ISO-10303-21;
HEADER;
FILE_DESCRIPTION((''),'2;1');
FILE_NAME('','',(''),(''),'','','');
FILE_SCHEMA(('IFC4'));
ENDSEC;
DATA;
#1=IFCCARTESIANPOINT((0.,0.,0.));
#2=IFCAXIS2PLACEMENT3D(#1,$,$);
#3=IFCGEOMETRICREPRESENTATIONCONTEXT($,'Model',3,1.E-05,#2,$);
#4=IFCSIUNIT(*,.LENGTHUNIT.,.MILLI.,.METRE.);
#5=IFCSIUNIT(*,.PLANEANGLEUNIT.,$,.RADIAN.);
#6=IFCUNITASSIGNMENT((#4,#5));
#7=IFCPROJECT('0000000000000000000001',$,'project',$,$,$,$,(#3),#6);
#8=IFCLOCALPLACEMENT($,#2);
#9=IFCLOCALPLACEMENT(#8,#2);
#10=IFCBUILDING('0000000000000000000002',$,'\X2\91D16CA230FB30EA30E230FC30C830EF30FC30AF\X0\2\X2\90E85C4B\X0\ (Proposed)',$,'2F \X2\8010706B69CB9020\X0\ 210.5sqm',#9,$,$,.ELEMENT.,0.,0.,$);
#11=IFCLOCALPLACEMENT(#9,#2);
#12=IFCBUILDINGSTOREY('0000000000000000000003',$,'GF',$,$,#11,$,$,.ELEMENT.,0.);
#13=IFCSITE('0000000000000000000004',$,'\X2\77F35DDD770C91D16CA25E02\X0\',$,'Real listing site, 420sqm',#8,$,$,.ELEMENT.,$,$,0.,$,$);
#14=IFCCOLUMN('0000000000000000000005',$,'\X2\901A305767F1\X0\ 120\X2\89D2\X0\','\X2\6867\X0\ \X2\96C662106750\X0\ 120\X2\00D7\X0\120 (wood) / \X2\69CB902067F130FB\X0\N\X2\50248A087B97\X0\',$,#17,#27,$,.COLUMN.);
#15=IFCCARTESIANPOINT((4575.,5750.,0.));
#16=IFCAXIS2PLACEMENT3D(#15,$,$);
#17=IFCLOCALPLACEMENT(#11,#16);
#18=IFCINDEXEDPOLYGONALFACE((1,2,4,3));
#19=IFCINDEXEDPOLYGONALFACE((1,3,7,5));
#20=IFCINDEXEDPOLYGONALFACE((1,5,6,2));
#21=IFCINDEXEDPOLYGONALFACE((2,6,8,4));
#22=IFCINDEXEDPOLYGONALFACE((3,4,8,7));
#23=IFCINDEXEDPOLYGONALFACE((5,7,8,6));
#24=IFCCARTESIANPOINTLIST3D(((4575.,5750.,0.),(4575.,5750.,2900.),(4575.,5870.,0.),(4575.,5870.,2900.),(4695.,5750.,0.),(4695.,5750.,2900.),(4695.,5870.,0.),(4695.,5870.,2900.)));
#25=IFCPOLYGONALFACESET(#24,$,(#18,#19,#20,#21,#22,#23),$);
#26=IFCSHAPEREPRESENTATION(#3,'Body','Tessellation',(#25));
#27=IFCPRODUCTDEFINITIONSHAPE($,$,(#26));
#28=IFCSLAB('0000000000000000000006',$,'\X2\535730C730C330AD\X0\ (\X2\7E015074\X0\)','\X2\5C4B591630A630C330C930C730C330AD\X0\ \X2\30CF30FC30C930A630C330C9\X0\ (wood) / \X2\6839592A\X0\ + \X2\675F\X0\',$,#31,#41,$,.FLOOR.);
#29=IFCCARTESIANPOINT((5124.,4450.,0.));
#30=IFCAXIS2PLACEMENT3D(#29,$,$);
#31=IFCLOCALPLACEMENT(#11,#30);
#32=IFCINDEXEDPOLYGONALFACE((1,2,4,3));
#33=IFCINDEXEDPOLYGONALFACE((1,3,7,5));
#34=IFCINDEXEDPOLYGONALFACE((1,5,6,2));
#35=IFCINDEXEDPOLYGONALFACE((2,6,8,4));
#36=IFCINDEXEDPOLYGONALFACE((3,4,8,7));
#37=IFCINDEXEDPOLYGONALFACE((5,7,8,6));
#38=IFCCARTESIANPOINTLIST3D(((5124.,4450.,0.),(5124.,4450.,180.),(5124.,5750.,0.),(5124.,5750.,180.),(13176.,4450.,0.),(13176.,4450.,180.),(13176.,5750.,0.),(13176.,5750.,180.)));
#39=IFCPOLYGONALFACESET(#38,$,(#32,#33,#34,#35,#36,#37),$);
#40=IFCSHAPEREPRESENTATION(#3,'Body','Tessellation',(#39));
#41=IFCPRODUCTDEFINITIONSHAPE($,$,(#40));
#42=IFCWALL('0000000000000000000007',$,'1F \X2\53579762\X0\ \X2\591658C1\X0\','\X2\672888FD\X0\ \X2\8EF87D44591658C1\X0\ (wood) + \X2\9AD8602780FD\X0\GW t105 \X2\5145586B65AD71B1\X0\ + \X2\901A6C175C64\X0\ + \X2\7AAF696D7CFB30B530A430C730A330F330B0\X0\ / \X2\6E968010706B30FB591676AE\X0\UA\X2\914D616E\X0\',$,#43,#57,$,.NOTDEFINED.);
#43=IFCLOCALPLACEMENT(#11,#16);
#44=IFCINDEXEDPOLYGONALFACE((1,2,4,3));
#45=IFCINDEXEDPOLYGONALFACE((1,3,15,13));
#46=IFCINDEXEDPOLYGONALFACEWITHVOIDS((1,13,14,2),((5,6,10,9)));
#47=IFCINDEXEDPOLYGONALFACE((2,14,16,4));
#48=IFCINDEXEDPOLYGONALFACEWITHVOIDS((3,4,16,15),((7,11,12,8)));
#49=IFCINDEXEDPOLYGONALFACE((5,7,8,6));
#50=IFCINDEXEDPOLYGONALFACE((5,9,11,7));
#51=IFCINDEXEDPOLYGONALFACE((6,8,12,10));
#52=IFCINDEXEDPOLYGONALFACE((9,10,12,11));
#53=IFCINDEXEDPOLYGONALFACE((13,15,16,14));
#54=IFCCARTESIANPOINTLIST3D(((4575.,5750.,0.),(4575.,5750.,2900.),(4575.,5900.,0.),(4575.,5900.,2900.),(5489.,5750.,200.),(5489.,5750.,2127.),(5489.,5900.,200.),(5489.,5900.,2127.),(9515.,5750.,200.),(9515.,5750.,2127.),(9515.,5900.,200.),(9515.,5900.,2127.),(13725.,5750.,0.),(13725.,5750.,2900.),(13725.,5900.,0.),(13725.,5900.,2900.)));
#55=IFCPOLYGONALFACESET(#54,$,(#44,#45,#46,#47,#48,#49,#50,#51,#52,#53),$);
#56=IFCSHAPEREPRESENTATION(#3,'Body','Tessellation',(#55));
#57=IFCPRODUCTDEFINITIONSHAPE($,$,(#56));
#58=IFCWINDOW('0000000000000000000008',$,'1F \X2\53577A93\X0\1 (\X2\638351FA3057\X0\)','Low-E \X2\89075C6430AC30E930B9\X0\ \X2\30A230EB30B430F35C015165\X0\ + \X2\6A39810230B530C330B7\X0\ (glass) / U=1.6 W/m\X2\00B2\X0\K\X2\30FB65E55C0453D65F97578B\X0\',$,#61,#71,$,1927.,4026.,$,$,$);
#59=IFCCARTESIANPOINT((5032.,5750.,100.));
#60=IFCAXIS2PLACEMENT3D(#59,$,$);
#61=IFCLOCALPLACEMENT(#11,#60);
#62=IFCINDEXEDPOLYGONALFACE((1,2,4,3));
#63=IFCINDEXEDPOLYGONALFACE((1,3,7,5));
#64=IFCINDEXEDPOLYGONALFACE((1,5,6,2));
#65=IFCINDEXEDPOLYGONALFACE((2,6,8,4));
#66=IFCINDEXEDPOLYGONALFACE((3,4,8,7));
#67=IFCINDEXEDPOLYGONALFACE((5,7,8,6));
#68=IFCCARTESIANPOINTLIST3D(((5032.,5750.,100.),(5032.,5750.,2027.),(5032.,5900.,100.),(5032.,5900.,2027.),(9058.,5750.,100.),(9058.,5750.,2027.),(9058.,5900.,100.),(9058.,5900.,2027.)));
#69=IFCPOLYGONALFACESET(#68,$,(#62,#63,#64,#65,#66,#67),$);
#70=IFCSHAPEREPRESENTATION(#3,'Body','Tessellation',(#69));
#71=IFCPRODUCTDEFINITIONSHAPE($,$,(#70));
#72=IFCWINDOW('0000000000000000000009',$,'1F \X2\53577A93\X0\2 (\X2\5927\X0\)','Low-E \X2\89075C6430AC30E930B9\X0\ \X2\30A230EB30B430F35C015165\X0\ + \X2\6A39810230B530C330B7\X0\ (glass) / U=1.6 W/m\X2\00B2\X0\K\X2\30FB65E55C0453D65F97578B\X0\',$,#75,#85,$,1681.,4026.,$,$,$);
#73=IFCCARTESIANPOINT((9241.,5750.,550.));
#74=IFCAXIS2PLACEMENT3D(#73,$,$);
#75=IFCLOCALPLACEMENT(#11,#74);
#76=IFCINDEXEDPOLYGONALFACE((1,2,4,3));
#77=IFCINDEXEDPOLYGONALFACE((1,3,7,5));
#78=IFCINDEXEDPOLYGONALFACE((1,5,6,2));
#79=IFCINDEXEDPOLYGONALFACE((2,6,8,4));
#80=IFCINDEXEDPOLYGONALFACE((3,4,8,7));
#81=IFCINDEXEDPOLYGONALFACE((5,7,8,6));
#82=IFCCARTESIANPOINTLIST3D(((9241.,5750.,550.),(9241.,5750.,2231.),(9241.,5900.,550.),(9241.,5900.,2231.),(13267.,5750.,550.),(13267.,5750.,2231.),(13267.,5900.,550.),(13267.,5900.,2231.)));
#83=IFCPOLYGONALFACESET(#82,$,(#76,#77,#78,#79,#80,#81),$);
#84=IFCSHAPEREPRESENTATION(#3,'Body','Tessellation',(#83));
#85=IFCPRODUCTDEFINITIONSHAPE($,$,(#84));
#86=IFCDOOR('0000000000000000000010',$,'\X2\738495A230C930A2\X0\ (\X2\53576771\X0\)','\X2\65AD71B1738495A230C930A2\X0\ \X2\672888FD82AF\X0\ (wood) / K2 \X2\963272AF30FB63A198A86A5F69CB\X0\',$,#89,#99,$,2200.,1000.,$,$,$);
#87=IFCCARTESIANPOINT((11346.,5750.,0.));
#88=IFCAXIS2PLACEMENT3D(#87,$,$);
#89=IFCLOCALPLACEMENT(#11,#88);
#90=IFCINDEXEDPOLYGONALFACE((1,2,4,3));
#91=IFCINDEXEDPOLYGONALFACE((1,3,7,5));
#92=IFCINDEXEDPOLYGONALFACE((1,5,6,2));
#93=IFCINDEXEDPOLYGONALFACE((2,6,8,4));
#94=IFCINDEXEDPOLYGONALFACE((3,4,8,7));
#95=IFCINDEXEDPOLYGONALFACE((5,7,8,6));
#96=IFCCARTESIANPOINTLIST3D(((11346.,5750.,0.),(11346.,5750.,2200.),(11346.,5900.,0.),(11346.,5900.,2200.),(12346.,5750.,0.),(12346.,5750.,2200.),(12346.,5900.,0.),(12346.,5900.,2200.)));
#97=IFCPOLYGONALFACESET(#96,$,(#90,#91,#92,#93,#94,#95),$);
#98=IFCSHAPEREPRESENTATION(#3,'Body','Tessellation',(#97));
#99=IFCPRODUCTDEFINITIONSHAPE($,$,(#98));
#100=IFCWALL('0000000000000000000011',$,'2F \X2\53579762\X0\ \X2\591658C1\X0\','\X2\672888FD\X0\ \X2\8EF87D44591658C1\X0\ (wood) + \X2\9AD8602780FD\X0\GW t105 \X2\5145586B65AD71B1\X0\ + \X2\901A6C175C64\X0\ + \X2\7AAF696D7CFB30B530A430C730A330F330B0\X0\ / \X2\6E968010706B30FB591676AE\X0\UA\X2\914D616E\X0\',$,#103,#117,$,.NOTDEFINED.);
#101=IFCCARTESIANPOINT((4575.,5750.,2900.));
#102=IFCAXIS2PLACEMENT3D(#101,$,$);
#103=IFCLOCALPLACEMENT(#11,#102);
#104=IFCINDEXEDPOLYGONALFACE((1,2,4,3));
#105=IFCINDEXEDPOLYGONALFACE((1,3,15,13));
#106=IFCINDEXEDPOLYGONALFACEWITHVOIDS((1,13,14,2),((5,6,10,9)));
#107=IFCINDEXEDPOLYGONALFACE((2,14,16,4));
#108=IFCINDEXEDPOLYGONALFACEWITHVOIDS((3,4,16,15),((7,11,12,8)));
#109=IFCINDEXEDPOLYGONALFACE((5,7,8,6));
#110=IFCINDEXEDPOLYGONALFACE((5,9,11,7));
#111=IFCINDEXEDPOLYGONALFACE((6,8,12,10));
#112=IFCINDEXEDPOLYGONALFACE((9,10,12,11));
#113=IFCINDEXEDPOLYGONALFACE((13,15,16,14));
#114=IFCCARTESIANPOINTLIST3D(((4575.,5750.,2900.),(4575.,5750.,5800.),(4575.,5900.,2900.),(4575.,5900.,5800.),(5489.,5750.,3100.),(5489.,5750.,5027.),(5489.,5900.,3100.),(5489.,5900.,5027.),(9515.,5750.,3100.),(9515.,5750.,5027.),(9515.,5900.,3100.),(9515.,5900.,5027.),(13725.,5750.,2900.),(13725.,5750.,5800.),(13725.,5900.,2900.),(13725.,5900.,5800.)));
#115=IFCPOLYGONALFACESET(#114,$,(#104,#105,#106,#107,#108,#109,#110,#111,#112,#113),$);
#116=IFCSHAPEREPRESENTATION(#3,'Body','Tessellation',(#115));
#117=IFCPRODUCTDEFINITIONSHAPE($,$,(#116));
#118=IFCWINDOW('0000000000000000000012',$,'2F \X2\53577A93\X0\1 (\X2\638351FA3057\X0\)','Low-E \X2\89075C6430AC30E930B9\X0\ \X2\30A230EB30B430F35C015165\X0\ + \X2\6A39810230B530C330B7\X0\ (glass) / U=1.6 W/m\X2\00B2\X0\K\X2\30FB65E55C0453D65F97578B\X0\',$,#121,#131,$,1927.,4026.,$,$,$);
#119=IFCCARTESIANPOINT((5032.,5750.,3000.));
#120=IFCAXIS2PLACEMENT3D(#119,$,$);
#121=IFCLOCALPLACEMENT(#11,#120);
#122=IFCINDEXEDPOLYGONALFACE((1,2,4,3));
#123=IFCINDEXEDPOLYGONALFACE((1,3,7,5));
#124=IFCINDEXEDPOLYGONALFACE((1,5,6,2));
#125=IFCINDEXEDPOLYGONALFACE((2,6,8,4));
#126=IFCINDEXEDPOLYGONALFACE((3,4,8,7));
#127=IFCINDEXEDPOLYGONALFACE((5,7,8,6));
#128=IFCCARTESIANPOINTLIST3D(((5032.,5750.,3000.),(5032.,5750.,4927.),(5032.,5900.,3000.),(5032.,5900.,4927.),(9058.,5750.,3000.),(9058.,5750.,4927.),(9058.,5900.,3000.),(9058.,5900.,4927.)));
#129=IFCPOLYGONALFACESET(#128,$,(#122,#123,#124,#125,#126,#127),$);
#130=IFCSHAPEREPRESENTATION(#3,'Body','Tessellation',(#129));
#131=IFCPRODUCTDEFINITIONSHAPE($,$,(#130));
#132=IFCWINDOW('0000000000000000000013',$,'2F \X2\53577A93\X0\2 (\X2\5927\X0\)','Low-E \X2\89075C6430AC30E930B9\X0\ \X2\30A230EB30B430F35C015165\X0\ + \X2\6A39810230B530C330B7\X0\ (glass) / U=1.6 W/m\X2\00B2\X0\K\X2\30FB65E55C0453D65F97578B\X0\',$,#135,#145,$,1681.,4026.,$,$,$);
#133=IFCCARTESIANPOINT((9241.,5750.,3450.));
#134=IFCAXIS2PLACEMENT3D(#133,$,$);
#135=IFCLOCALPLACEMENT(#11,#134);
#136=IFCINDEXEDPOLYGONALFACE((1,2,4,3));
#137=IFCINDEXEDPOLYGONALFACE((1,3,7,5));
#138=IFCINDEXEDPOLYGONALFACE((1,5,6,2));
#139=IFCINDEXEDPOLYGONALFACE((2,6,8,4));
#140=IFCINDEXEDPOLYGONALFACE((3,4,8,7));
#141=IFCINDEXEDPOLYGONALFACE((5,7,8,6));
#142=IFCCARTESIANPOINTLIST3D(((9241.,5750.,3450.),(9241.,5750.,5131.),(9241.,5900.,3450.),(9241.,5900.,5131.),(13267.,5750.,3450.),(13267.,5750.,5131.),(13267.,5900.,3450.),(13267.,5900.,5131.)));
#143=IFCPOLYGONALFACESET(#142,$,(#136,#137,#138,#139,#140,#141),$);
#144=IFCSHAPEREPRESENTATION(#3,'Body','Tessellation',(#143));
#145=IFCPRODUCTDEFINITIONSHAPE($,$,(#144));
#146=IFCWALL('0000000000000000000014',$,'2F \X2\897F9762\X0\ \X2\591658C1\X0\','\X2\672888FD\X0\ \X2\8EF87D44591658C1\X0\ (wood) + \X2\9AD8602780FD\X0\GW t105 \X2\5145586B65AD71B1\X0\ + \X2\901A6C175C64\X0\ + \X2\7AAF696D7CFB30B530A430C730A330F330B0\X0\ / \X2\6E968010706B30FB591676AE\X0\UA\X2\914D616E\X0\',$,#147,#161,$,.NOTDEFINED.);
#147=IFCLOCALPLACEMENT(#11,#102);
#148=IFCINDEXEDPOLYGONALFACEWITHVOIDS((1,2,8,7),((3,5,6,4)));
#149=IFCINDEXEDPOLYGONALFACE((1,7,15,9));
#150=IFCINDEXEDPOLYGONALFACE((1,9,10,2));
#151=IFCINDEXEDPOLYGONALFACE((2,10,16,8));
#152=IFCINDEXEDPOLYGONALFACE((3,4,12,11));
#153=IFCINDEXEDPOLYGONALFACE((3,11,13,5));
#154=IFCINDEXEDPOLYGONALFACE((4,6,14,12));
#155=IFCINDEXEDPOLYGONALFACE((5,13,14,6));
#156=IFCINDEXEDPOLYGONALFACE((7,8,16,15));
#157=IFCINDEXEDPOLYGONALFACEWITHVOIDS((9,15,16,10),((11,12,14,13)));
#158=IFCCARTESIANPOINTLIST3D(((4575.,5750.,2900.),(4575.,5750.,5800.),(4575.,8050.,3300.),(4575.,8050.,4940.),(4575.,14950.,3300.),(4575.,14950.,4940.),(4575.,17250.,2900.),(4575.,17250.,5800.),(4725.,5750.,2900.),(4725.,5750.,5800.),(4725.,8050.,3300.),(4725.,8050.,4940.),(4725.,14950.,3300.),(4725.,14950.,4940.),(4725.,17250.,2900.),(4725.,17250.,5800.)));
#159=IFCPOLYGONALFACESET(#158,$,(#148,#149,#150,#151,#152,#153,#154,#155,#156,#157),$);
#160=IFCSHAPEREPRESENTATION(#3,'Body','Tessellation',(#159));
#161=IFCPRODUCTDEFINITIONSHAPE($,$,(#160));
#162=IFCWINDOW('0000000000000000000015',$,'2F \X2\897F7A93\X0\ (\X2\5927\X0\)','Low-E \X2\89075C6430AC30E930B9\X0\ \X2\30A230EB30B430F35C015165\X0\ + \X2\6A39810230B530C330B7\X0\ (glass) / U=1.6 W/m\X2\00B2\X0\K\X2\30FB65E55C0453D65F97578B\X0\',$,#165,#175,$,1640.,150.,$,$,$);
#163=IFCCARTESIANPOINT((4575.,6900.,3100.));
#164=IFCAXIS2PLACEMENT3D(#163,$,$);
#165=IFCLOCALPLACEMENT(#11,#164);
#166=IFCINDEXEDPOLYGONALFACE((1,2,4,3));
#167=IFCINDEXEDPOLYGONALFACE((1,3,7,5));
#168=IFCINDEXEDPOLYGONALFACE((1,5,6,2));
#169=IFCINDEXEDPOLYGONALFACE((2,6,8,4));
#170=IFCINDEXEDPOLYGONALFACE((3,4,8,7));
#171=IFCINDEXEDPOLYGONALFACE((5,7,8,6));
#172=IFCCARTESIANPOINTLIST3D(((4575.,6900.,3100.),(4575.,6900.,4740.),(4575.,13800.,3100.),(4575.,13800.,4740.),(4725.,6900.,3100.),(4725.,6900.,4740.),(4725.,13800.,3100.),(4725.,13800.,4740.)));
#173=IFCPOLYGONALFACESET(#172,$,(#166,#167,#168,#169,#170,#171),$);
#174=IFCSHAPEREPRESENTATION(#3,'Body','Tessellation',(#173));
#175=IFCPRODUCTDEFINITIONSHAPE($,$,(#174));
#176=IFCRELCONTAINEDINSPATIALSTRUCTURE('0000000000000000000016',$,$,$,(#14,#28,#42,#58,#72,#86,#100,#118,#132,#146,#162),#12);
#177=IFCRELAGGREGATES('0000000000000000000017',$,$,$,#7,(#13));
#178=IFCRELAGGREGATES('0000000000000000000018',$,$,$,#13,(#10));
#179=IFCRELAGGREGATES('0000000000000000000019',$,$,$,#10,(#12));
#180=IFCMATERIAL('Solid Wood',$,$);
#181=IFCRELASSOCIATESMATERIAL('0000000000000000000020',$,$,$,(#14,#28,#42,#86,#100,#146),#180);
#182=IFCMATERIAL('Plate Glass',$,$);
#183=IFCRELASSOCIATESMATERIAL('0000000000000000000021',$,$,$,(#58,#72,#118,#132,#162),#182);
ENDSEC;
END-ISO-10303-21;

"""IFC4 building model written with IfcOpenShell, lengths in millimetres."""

from ifc_helpers import new_model, si_unit, frame, frame_2d, origin, place, context, project, spatial, rectangle, extrude, material, element, fill, save


model = new_model("IFC4")

# Units and contexts
model_context = context("Model", 3, precision=1e-05, world=origin())
ifc_project = project(units=[si_unit("LENGTHUNIT", "METRE", prefix="MILLI"), si_unit("PLANEANGLEUNIT", "RADIAN")], contexts=[model_context])

# Site, building, storey
site_placement = place(None, origin())
site = spatial("IfcSite", under=ifc_project, at=site_placement, Name="石川県金沢市", ObjectType="Real listing site, 420sqm", CompositionType="ELEMENT", RefElevation=0.0)
building_placement = place(site_placement, origin())
building = spatial("IfcBuilding", under=site, at=building_placement, Name="金沢・リモートワーク2部屋 (Proposed)", ObjectType="2F 耐火構造 210.5sqm", CompositionType="ELEMENT", ElevationOfRefHeight=0.0, ElevationOfTerrain=0.0)
storey_placement = place(building_placement, origin())
storey = spatial("IfcBuildingStorey", under=building, at=storey_placement, Name="GF", CompositionType="ELEMENT", Elevation=0.0)

# Column
ifc_material_1 = material(Name="Solid Wood")
column_placement = place(storey_placement, frame((4575.0, 5750.0, 0.0)))
element("IfcColumn", 1, at=column_placement, inside=storey, material=ifc_material_1, Name="通し柱 120角", Description="桧 集成材 120×120 (wood) / 構造柱・N値計算", PredefinedType="COLUMN", context=model_context, shape_type="SweptSolid", body=[
    extrude(rectangle(XDim=120.0, YDim=120.0, at=frame_2d((60.0, 60.0))), frame((4575.0, 5750.0, 0.0)), (0.0, 0.0, 1.0), 2900.0),
])

# Slab
slab_1_placement = place(storey_placement, frame((5124.0, 4450.0, 0.0)))
element("IfcSlab", 2, at=slab_1_placement, inside=storey, material=ifc_material_1, Name="南デッキ (縁側)", Description="屋外ウッドデッキ ハードウッド (wood) / 根太 + 束", PredefinedType="FLOOR", context=model_context, shape_type="SweptSolid", body=[
    extrude(rectangle(XDim=8052.0, YDim=1300.0, at=frame_2d((4026.0, 650.0))), frame((5124.0, 4450.0, 0.0)), (0.0, 0.0, 1.0), 180.0),
])

# Wall, openings, windows, door
wall_1_placement = place(storey_placement, frame((4575.0, 5750.0, 0.0)))
wall_1 = element("IfcWall", 3, at=wall_1_placement, inside=storey, material=ifc_material_1, Name="1F 南面 外壁", Description="木製 軸組外壁 (wood) + 高性能GW t105 充填断熱 + 通気層 + 窯業系サイディング / 準耐火・外皮UA配慮", PredefinedType="NOTDEFINED", context=model_context, shape_type="SweptSolid", body=[
    extrude(rectangle(XDim=9150.0, YDim=150.0, at=frame_2d((4575.0, 75.0))), frame((4575.0, 5750.0, 0.0)), (0.0, 0.0, 1.0), 2900.0),
])
opening_1_placement = place(storey_placement, frame((5032.0, 5750.0, 100.0)))
opening_1 = element("IfcOpeningElement", 4, at=opening_1_placement, cuts=wall_1, PredefinedType="NOTDEFINED", context=model_context, shape_type="SweptSolid", body=[
    extrude(rectangle(XDim=4026.0, YDim=150.0, at=frame_2d((2013.0, 75.0))), frame((5032.0, 5750.0, 100.0)), (0.0, 0.0, 1.0), 1927.0),
])
opening_2_placement = place(storey_placement, frame((9241.0, 5750.0, 550.0)))
opening_2 = element("IfcOpeningElement", 5, at=opening_2_placement, cuts=wall_1, PredefinedType="NOTDEFINED", context=model_context, shape_type="SweptSolid", body=[
    extrude(rectangle(XDim=4026.0, YDim=150.0, at=frame_2d((2013.0, 75.0))), frame((9241.0, 5750.0, 550.0)), (0.0, 0.0, 1.0), 1681.0),
])
opening_3_placement = place(storey_placement, frame((11346.0, 5750.0, 0.0)))
opening_3 = element("IfcOpeningElement", 6, at=opening_3_placement, cuts=wall_1, PredefinedType="NOTDEFINED", context=model_context, shape_type="SweptSolid", body=[
    extrude(rectangle(XDim=1000.0, YDim=150.0, at=frame_2d((500.0, 75.0))), frame((11346.0, 5750.0, 0.0)), (0.0, 0.0, 1.0), 2200.0),
])
ifc_material_2 = material(Name="Plate Glass")
window_1_placement = place(storey_placement, frame((5032.0, 5750.0, 100.0)))
window_1 = element("IfcWindow", 7, at=window_1_placement, inside=storey, material=ifc_material_2, Name="1F 南窓1 (掃出し)", Description="Low-E 複層ガラス アルゴン封入 + 樹脂サッシ (glass) / U=1.6 W/m²K・日射取得型", OverallHeight=1927.0, OverallWidth=4026.0, context=model_context, shape_type="SweptSolid", body=[
    extrude(rectangle(XDim=4026.0, YDim=150.0, at=frame_2d((2013.0, 75.0))), frame((5032.0, 5750.0, 100.0)), (0.0, 0.0, 1.0), 1927.0),
])
fill(opening_1, window_1)
window_2_placement = place(storey_placement, frame((9241.0, 5750.0, 550.0)))
window_2 = element("IfcWindow", 8, at=window_2_placement, inside=storey, material=ifc_material_2, Name="1F 南窓2 (大)", Description="Low-E 複層ガラス アルゴン封入 + 樹脂サッシ (glass) / U=1.6 W/m²K・日射取得型", OverallHeight=1681.0, OverallWidth=4026.0, context=model_context, shape_type="SweptSolid", body=[
    extrude(rectangle(XDim=4026.0, YDim=150.0, at=frame_2d((2013.0, 75.0))), frame((9241.0, 5750.0, 550.0)), (0.0, 0.0, 1.0), 1681.0),
])
fill(opening_2, window_2)
door_placement = place(storey_placement, frame((11346.0, 5750.0, 0.0)))
door = element("IfcDoor", 9, at=door_placement, inside=storey, material=ifc_material_1, Name="玄関ドア (南東)", Description="断熱玄関ドア 木製芯 (wood) / K2 防犯・採風機構", OverallHeight=2200.0, OverallWidth=1000.0, context=model_context, shape_type="SweptSolid", body=[
    extrude(rectangle(XDim=1000.0, YDim=150.0, at=frame_2d((500.0, 75.0))), frame((11346.0, 5750.0, 0.0)), (0.0, 0.0, 1.0), 2200.0),
])
fill(opening_3, door)

# Wall, openings, windows
wall_2_placement = place(storey_placement, frame((4575.0, 5750.0, 2900.0)))
wall_2 = element("IfcWall", 10, at=wall_2_placement, inside=storey, material=ifc_material_1, Name="2F 南面 外壁", Description="木製 軸組外壁 (wood) + 高性能GW t105 充填断熱 + 通気層 + 窯業系サイディング / 準耐火・外皮UA配慮", PredefinedType="NOTDEFINED", context=model_context, shape_type="SweptSolid", body=[
    extrude(rectangle(XDim=9150.0, YDim=150.0, at=frame_2d((4575.0, 75.0))), frame((4575.0, 5750.0, 2900.0)), (0.0, 0.0, 1.0), 2900.0),
])
opening_4_placement = place(storey_placement, frame((5032.0, 5750.0, 3000.0)))
opening_4 = element("IfcOpeningElement", 11, at=opening_4_placement, cuts=wall_2, PredefinedType="NOTDEFINED", context=model_context, shape_type="SweptSolid", body=[
    extrude(rectangle(XDim=4026.0, YDim=150.0, at=frame_2d((2013.0, 75.0))), frame((5032.0, 5750.0, 3000.0)), (0.0, 0.0, 1.0), 1927.0),
])
opening_5_placement = place(storey_placement, frame((9241.0, 5750.0, 3450.0)))
opening_5 = element("IfcOpeningElement", 12, at=opening_5_placement, cuts=wall_2, PredefinedType="NOTDEFINED", context=model_context, shape_type="SweptSolid", body=[
    extrude(rectangle(XDim=4026.0, YDim=150.0, at=frame_2d((2013.0, 75.0))), frame((9241.0, 5750.0, 3450.0)), (0.0, 0.0, 1.0), 1681.0),
])
window_3_placement = place(storey_placement, frame((5032.0, 5750.0, 3000.0)))
window_3 = element("IfcWindow", 13, at=window_3_placement, inside=storey, material=ifc_material_2, Name="2F 南窓1 (掃出し)", Description="Low-E 複層ガラス アルゴン封入 + 樹脂サッシ (glass) / U=1.6 W/m²K・日射取得型", OverallHeight=1927.0, OverallWidth=4026.0, context=model_context, shape_type="SweptSolid", body=[
    extrude(rectangle(XDim=4026.0, YDim=150.0, at=frame_2d((2013.0, 75.0))), frame((5032.0, 5750.0, 3000.0)), (0.0, 0.0, 1.0), 1927.0),
])
fill(opening_4, window_3)
window_4_placement = place(storey_placement, frame((9241.0, 5750.0, 3450.0)))
window_4 = element("IfcWindow", 14, at=window_4_placement, inside=storey, material=ifc_material_2, Name="2F 南窓2 (大)", Description="Low-E 複層ガラス アルゴン封入 + 樹脂サッシ (glass) / U=1.6 W/m²K・日射取得型", OverallHeight=1681.0, OverallWidth=4026.0, context=model_context, shape_type="SweptSolid", body=[
    extrude(rectangle(XDim=4026.0, YDim=150.0, at=frame_2d((2013.0, 75.0))), frame((9241.0, 5750.0, 3450.0)), (0.0, 0.0, 1.0), 1681.0),
])
fill(opening_5, window_4)

# Wall, opening, window
wall_3_placement = place(storey_placement, frame((4575.0, 5750.0, 2900.0)))
wall_3 = element("IfcWall", 15, at=wall_3_placement, inside=storey, material=ifc_material_1, Name="2F 西面 外壁", Description="木製 軸組外壁 (wood) + 高性能GW t105 充填断熱 + 通気層 + 窯業系サイディング / 準耐火・外皮UA配慮", PredefinedType="NOTDEFINED", context=model_context, shape_type="SweptSolid", body=[
    extrude(rectangle(XDim=150.0, YDim=11500.0, at=frame_2d((75.0, 5750.0))), frame((4575.0, 5750.0, 2900.0)), (0.0, 0.0, 1.0), 2900.0),
])
opening_6_placement = place(storey_placement, frame((4575.0, 6900.0, 3100.0)))
opening_6 = element("IfcOpeningElement", 16, at=opening_6_placement, cuts=wall_3, PredefinedType="NOTDEFINED", context=model_context, shape_type="SweptSolid", body=[
    extrude(rectangle(XDim=150.0, YDim=6900.0, at=frame_2d((75.0, 3450.0))), frame((4575.0, 6900.0, 3100.0)), (0.0, 0.0, 1.0), 1640.0),
])
window_5_placement = place(storey_placement, frame((4575.0, 6900.0, 3100.0)))
window_5 = element("IfcWindow", 17, at=window_5_placement, inside=storey, material=ifc_material_2, Name="2F 西窓 (大)", Description="Low-E 複層ガラス アルゴン封入 + 樹脂サッシ (glass) / U=1.6 W/m²K・日射取得型", OverallHeight=1640.0, OverallWidth=150.0, context=model_context, shape_type="SweptSolid", body=[
    extrude(rectangle(XDim=150.0, YDim=6900.0, at=frame_2d((75.0, 3450.0))), frame((4575.0, 6900.0, 3100.0)), (0.0, 0.0, 1.0), 1640.0),
])
fill(opening_6, window_5)

save(model, "model.ifc")
